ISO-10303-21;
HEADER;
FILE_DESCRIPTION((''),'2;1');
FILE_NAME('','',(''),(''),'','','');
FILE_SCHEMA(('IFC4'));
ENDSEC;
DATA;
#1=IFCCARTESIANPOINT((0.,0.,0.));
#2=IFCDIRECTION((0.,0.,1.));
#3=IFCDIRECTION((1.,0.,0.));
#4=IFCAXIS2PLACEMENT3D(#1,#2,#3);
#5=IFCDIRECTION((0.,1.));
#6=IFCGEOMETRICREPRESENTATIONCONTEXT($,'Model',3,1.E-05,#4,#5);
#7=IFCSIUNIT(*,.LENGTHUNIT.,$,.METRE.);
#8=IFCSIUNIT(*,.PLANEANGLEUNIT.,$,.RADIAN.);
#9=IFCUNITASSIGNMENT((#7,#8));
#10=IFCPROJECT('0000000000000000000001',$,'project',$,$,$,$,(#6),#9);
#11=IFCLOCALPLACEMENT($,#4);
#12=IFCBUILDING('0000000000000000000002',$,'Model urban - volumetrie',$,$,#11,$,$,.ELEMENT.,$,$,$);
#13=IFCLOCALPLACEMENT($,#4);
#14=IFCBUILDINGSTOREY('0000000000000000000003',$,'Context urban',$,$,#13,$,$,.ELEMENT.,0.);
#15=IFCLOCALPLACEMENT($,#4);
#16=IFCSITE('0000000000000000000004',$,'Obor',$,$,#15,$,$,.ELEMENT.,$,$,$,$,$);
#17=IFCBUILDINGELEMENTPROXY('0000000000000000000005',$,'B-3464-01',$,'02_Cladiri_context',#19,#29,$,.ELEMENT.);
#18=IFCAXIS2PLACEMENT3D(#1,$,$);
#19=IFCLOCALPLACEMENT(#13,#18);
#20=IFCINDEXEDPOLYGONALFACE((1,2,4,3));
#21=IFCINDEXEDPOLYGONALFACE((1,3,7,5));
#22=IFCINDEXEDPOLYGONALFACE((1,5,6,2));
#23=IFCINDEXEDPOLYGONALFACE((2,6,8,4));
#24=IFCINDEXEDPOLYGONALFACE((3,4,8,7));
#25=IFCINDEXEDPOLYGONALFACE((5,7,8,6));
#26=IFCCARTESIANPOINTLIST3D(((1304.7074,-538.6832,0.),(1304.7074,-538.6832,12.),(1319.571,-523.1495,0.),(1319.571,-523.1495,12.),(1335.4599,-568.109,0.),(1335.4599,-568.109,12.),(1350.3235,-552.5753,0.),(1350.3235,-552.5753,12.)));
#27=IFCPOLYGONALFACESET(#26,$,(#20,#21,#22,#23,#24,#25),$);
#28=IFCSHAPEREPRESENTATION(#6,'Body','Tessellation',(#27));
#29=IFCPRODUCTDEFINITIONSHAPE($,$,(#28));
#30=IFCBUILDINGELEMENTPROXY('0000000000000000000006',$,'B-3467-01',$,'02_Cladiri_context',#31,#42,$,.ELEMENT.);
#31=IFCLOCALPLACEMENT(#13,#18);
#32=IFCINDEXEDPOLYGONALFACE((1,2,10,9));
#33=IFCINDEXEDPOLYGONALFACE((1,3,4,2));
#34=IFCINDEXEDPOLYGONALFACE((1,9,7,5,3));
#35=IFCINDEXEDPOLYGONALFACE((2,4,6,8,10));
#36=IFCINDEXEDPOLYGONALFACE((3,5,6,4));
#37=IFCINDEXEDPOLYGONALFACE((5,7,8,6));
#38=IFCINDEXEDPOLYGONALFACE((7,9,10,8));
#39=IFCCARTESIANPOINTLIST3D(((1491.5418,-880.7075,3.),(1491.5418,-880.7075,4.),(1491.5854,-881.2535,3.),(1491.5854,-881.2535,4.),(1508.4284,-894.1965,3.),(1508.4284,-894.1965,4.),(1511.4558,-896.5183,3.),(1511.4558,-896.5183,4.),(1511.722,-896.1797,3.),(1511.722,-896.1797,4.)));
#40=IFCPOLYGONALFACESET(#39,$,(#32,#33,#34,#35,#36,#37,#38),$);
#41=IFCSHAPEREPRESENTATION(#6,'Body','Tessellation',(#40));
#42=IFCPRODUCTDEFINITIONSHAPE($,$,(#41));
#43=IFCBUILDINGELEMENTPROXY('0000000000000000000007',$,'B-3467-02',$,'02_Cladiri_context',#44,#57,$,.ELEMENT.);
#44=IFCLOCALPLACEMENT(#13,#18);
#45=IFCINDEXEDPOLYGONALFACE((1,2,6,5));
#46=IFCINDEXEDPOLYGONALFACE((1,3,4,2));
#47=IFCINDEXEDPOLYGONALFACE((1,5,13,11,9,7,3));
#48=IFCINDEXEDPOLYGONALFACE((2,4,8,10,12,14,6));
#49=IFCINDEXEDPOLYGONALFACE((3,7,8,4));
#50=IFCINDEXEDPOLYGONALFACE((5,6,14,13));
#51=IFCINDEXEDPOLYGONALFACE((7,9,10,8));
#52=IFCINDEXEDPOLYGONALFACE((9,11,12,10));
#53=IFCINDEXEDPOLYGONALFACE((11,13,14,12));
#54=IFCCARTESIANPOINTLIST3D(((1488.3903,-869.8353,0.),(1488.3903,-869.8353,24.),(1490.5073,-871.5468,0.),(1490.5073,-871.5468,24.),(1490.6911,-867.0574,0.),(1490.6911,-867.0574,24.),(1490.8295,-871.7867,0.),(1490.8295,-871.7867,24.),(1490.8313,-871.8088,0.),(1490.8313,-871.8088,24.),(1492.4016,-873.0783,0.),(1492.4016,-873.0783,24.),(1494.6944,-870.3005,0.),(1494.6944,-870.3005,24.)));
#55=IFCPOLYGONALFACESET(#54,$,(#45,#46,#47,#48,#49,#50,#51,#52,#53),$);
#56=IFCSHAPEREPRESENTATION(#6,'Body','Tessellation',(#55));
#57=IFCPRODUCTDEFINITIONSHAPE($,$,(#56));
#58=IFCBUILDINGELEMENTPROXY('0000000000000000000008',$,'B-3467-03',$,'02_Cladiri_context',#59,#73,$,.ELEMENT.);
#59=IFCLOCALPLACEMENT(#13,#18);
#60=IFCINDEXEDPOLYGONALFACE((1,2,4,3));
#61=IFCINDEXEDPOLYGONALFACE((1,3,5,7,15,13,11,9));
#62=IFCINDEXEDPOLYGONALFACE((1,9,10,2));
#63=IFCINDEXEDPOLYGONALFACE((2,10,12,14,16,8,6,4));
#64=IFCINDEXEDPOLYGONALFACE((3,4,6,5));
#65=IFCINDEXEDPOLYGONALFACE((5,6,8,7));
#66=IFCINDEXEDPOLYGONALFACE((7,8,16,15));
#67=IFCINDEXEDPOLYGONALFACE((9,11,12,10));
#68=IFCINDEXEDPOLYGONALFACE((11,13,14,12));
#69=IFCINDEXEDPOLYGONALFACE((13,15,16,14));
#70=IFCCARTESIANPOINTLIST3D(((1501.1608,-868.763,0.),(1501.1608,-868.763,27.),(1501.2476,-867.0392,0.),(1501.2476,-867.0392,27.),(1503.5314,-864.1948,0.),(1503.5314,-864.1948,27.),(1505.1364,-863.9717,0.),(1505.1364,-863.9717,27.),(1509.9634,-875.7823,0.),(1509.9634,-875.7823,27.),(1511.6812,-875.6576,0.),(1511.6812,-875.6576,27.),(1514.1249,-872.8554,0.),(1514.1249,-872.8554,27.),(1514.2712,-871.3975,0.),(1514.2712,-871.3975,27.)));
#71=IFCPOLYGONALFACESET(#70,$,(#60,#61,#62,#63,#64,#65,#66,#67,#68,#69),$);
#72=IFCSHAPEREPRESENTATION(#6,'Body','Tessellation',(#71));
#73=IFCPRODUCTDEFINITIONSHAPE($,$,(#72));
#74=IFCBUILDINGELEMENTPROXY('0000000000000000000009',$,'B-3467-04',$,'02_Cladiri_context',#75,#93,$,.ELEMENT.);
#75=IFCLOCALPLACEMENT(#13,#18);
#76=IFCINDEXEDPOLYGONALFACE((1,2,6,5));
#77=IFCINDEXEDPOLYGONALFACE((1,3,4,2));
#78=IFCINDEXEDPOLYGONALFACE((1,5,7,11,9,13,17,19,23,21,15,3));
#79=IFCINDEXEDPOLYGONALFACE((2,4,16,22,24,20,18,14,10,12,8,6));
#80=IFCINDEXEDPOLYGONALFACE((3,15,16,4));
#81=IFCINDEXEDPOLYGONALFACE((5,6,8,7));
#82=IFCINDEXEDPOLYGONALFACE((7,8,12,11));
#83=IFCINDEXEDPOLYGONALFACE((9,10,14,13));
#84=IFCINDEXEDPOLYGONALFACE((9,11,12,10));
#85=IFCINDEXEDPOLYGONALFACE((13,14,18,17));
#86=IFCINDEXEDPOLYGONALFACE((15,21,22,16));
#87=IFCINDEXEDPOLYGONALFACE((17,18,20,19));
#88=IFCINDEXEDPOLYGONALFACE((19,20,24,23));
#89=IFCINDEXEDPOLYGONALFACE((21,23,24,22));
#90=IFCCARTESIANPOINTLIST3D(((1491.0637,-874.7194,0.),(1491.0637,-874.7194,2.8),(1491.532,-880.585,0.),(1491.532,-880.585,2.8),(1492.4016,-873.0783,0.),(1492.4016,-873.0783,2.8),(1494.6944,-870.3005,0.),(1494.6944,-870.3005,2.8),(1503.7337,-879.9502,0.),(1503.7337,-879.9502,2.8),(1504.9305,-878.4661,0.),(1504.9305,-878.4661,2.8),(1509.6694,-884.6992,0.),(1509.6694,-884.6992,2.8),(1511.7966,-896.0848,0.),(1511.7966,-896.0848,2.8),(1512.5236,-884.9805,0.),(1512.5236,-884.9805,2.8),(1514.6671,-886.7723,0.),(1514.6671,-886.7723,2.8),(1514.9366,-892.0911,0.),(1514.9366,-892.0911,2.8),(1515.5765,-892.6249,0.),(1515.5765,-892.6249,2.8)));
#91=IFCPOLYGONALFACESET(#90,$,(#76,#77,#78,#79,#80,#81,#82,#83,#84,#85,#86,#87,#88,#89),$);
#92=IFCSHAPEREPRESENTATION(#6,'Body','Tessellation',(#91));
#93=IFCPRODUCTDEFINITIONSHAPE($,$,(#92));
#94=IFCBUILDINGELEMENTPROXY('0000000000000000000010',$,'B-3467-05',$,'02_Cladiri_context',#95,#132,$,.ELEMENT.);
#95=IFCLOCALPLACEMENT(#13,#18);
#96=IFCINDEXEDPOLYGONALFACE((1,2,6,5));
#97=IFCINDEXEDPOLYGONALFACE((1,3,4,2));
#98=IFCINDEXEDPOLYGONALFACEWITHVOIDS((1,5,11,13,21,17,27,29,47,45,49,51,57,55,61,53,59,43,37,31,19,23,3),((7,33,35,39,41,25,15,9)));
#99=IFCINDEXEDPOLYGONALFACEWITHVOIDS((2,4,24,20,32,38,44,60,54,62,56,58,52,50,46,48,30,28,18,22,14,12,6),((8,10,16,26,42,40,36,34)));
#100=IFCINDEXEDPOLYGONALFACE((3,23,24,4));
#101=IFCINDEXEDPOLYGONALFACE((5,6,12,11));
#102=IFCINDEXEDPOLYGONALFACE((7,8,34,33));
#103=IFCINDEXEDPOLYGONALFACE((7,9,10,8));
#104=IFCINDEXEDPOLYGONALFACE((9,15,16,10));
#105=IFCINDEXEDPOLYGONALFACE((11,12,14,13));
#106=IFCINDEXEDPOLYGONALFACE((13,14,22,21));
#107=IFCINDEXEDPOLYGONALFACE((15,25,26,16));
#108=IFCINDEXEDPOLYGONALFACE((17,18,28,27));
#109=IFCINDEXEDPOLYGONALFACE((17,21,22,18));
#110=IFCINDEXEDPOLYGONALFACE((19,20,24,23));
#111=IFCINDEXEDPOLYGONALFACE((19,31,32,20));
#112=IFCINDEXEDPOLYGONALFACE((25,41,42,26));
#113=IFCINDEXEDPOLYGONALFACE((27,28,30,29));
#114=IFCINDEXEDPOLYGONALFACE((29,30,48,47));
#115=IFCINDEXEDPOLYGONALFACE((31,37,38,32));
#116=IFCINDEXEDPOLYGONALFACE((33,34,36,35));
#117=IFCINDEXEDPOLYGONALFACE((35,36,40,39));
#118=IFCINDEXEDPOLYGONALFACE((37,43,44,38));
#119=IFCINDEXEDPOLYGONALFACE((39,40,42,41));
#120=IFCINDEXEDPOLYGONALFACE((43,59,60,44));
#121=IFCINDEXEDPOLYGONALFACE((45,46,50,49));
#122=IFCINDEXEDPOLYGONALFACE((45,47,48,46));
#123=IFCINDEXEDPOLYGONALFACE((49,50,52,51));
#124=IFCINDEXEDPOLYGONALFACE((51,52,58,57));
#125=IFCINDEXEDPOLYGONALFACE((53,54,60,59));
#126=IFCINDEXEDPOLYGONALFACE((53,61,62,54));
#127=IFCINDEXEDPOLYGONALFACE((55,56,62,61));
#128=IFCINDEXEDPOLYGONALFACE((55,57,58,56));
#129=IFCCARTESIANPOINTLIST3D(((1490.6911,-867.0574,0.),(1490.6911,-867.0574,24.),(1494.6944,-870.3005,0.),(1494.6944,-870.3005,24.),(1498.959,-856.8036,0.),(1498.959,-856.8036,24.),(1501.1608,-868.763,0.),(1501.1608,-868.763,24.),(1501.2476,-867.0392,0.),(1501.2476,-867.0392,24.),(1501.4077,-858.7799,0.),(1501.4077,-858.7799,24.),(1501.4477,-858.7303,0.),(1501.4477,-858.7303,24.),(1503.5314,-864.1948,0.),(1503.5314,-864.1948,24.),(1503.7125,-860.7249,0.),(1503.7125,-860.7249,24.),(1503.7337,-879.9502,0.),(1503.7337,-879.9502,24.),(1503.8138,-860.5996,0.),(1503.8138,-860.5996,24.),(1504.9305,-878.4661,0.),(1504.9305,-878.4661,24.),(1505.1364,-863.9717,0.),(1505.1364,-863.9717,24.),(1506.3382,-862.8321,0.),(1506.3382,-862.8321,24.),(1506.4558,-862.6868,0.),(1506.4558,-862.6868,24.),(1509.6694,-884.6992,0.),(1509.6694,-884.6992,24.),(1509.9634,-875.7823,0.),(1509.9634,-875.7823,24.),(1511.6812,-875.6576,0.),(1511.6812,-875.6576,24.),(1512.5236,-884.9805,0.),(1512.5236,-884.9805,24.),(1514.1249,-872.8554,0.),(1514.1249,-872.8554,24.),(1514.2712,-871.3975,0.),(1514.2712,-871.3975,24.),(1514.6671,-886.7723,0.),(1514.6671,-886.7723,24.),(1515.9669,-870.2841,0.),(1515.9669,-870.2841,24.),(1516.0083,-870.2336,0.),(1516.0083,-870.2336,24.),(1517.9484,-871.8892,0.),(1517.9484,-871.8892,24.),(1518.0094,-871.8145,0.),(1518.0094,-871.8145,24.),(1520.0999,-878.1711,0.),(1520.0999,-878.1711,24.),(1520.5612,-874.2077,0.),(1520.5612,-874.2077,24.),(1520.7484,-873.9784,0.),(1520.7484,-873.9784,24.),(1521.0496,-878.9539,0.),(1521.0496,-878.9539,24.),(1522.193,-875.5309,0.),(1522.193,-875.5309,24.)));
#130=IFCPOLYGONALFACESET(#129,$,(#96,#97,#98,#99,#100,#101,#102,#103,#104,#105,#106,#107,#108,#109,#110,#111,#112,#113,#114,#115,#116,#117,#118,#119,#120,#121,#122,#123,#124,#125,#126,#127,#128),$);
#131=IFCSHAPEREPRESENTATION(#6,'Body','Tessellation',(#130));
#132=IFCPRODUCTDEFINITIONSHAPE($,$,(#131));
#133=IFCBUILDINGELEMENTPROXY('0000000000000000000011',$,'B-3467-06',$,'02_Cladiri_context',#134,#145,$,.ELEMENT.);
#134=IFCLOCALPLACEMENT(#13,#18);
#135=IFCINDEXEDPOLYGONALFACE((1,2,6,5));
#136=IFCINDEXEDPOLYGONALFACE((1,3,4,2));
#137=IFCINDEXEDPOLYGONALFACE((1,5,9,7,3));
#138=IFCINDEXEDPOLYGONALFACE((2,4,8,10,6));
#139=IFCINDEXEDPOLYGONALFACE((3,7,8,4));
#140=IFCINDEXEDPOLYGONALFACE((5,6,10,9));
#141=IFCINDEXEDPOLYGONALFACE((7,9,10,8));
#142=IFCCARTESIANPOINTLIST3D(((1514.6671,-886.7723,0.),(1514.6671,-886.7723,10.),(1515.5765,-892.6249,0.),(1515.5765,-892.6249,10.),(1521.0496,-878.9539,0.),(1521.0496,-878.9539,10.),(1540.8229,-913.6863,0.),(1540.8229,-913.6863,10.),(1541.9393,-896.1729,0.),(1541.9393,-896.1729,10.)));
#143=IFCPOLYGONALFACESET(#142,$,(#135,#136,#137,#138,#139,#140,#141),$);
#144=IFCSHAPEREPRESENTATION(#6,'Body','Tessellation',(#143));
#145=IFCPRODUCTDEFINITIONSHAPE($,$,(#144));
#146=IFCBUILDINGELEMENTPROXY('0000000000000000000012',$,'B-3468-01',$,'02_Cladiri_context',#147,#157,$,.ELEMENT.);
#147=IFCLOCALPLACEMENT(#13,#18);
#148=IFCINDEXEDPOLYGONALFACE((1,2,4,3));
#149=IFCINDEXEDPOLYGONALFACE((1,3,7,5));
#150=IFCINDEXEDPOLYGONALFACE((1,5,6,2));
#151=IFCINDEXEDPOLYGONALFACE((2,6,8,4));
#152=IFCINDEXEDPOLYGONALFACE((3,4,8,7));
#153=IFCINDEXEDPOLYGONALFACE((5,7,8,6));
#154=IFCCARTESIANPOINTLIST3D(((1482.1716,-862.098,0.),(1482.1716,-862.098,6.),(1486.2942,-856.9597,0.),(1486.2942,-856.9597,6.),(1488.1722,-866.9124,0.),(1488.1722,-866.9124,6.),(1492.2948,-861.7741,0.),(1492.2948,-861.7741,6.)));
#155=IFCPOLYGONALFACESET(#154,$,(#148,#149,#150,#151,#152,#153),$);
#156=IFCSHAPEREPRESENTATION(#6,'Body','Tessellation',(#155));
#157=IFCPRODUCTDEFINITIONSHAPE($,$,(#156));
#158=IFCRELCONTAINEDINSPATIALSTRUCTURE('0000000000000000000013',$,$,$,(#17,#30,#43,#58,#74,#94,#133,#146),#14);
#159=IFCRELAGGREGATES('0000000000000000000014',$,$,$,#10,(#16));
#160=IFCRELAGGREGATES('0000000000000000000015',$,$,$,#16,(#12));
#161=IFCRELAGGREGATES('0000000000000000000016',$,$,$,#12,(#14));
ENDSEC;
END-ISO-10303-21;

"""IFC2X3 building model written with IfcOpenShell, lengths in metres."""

from ifc_helpers import new_model, si_unit, direction, frame, origin_with_axes, place, context, project, spatial, polyline, outline, extrude, element, save


model = new_model("IFC2X3")

# Units and contexts
model_context = context("Model", 3, precision=1e-05, world=origin_with_axes(), true_north=direction((0.0, 1.0)))
ifc_project = project(units=[si_unit("LENGTHUNIT", "METRE"), si_unit("PLANEANGLEUNIT", "RADIAN")], contexts=[model_context])

# Site, building, storey
site_placement = place(None, origin_with_axes())
site = spatial("IfcSite", under=ifc_project, at=site_placement, Name="Obor", CompositionType="ELEMENT")
building_placement = place(None, origin_with_axes())
building = spatial("IfcBuilding", under=site, at=building_placement, Name="Model urban - volumetrie", CompositionType="ELEMENT")
storey_placement = place(None, origin_with_axes())
storey = spatial("IfcBuildingStorey", under=building, at=storey_placement, Name="Context urban", CompositionType="ELEMENT", Elevation=0.0)

# Building element proxies
proxy_1_placement = place(None, origin_with_axes())
element("IfcBuildingElementProxy", 1, at=proxy_1_placement, inside=storey, Name="B-3464-01", ObjectType="02_Cladiri_context", CompositionType="ELEMENT", context=model_context, shape_type="SweptSolid", body=[
    extrude(outline(polyline([(1335.4599, -568.109), (1350.3235, -552.5753), (1319.571, -523.1495), (1304.7074, -538.6832), (1335.4599, -568.109)])), origin_with_axes(), (0.0, 0.0, 1.0), 12.0),
])
proxy_2_placement = place(None, origin_with_axes())
element("IfcBuildingElementProxy", 2, at=proxy_2_placement, inside=storey, Name="B-3467-01", ObjectType="02_Cladiri_context", CompositionType="ELEMENT", context=model_context, shape_type="SweptSolid", body=[
    extrude(outline(polyline([(1508.4284, -894.1965), (1511.4558, -896.5183), (1511.722, -896.1797), (1491.5418, -880.7075), (1491.5854, -881.2535), (1508.4284, -894.1965)])), frame((0.0, 0.0, 3.0), z_axis=(0.0, 0.0, 1.0), x_axis=(1.0, 0.0, 0.0)), (0.0, 0.0, 1.0), 1.0),
])
proxy_3_placement = place(None, origin_with_axes())
element("IfcBuildingElementProxy", 3, at=proxy_3_placement, inside=storey, Name="B-3467-02", ObjectType="02_Cladiri_context", CompositionType="ELEMENT", context=model_context, shape_type="SweptSolid", body=[
    extrude(outline(polyline([(1490.5073, -871.5468), (1490.8295, -871.7867), (1490.8313, -871.8088), (1492.4016, -873.0783), (1494.6944, -870.3005), (1490.6911, -867.0574), (1488.3903, -869.8353), (1490.5073, -871.5468)])), origin_with_axes(), (0.0, 0.0, 1.0), 24.0),
])
proxy_4_placement = place(None, origin_with_axes())
element("IfcBuildingElementProxy", 4, at=proxy_4_placement, inside=storey, Name="B-3467-03", ObjectType="02_Cladiri_context", CompositionType="ELEMENT", context=model_context, shape_type="SweptSolid", body=[
    extrude(outline(polyline([(1505.1364, -863.9717), (1503.5314, -864.1948), (1501.2476, -867.0392), (1501.1608, -868.763), (1509.9634, -875.7823), (1511.6812, -875.6576), (1514.1249, -872.8554), (1514.2712, -871.3975), (1505.1364, -863.9717)])), origin_with_axes(), (0.0, 0.0, 1.0), 27.0),
])
proxy_5_placement = place(None, origin_with_axes())
element("IfcBuildingElementProxy", 5, at=proxy_5_placement, inside=storey, Name="B-3467-04", ObjectType="02_Cladiri_context", CompositionType="ELEMENT", context=model_context, shape_type="SweptSolid", body=[
    extrude(outline(polyline([(1511.7966, -896.0848), (1514.9366, -892.0911), (1515.5765, -892.6249), (1514.6671, -886.7723), (1512.5236, -884.9805), (1509.6694, -884.6992), (1503.7337, -879.9502), (1504.9305, -878.4661), (1494.6944, -870.3005), (1492.4016, -873.0783), (1491.0637, -874.7194), (1491.532, -880.585), (1511.7966, -896.0848)])), origin_with_axes(), (0.0, 0.0, 1.0), 2.8),
])
proxy_6_placement = place(None, origin_with_axes())
element("IfcBuildingElementProxy", 6, at=proxy_6_placement, inside=storey, Name="B-3467-05", ObjectType="02_Cladiri_context", CompositionType="ELEMENT", context=model_context, shape_type="SweptSolid", body=[
    extrude(outline(polyline([(1503.7125, -860.7249), (1503.8138, -860.5996), (1501.4477, -858.7303), (1501.4077, -858.7799), (1498.959, -856.8036), (1490.6911, -867.0574), (1494.6944, -870.3005), (1504.9305, -878.4661), (1503.7337, -879.9502), (1509.6694, -884.6992), (1512.5236, -884.9805), (1514.6671, -886.7723), (1521.0496, -878.9539), (1520.0999, -878.1711), (1522.193, -875.5309), (1520.5612, -874.2077), (1520.7484, -873.9784), (1518.0094, -871.8145), (1517.9484, -871.8892), (1515.9669, -870.2841), (1516.0083, -870.2336), (1506.4558, -862.6868), (1506.3382, -862.8321), (1503.7125, -860.7249)]), holes=[polyline([(1511.6812, -875.6576), (1509.9634, -875.7823), (1501.1608, -868.763), (1501.2476, -867.0392), (1503.5314, -864.1948), (1505.1364, -863.9717), (1514.2712, -871.3975), (1514.1249, -872.8554), (1511.6812, -875.6576)])]), origin_with_axes(), (0.0, 0.0, 1.0), 24.0),
])
proxy_7_placement = place(None, origin_with_axes())
element("IfcBuildingElementProxy", 7, at=proxy_7_placement, inside=storey, Name="B-3467-06", ObjectType="02_Cladiri_context", CompositionType="ELEMENT", context=model_context, shape_type="SweptSolid", body=[
    extrude(outline(polyline([(1540.8229, -913.6863), (1541.9393, -896.1729), (1520.0999, -878.1711), (1521.0496, -878.9539), (1514.6671, -886.7723), (1515.5765, -892.6249), (1514.9366, -892.0911), (1540.8229, -913.6863)])), origin_with_axes(), (0.0, 0.0, 1.0), 10.0),
])
proxy_8_placement = place(None, origin_with_axes())
element("IfcBuildingElementProxy", 8, at=proxy_8_placement, inside=storey, Name="B-3468-01", ObjectType="02_Cladiri_context", CompositionType="ELEMENT", context=model_context, shape_type="SweptSolid", body=[
    extrude(outline(polyline([(1482.1716, -862.098), (1488.1722, -866.9124), (1492.2948, -861.7741), (1486.2942, -856.9597), (1482.1716, -862.098)])), origin_with_axes(), (0.0, 0.0, 1.0), 6.0),
])

save(model, "model.ifc")
